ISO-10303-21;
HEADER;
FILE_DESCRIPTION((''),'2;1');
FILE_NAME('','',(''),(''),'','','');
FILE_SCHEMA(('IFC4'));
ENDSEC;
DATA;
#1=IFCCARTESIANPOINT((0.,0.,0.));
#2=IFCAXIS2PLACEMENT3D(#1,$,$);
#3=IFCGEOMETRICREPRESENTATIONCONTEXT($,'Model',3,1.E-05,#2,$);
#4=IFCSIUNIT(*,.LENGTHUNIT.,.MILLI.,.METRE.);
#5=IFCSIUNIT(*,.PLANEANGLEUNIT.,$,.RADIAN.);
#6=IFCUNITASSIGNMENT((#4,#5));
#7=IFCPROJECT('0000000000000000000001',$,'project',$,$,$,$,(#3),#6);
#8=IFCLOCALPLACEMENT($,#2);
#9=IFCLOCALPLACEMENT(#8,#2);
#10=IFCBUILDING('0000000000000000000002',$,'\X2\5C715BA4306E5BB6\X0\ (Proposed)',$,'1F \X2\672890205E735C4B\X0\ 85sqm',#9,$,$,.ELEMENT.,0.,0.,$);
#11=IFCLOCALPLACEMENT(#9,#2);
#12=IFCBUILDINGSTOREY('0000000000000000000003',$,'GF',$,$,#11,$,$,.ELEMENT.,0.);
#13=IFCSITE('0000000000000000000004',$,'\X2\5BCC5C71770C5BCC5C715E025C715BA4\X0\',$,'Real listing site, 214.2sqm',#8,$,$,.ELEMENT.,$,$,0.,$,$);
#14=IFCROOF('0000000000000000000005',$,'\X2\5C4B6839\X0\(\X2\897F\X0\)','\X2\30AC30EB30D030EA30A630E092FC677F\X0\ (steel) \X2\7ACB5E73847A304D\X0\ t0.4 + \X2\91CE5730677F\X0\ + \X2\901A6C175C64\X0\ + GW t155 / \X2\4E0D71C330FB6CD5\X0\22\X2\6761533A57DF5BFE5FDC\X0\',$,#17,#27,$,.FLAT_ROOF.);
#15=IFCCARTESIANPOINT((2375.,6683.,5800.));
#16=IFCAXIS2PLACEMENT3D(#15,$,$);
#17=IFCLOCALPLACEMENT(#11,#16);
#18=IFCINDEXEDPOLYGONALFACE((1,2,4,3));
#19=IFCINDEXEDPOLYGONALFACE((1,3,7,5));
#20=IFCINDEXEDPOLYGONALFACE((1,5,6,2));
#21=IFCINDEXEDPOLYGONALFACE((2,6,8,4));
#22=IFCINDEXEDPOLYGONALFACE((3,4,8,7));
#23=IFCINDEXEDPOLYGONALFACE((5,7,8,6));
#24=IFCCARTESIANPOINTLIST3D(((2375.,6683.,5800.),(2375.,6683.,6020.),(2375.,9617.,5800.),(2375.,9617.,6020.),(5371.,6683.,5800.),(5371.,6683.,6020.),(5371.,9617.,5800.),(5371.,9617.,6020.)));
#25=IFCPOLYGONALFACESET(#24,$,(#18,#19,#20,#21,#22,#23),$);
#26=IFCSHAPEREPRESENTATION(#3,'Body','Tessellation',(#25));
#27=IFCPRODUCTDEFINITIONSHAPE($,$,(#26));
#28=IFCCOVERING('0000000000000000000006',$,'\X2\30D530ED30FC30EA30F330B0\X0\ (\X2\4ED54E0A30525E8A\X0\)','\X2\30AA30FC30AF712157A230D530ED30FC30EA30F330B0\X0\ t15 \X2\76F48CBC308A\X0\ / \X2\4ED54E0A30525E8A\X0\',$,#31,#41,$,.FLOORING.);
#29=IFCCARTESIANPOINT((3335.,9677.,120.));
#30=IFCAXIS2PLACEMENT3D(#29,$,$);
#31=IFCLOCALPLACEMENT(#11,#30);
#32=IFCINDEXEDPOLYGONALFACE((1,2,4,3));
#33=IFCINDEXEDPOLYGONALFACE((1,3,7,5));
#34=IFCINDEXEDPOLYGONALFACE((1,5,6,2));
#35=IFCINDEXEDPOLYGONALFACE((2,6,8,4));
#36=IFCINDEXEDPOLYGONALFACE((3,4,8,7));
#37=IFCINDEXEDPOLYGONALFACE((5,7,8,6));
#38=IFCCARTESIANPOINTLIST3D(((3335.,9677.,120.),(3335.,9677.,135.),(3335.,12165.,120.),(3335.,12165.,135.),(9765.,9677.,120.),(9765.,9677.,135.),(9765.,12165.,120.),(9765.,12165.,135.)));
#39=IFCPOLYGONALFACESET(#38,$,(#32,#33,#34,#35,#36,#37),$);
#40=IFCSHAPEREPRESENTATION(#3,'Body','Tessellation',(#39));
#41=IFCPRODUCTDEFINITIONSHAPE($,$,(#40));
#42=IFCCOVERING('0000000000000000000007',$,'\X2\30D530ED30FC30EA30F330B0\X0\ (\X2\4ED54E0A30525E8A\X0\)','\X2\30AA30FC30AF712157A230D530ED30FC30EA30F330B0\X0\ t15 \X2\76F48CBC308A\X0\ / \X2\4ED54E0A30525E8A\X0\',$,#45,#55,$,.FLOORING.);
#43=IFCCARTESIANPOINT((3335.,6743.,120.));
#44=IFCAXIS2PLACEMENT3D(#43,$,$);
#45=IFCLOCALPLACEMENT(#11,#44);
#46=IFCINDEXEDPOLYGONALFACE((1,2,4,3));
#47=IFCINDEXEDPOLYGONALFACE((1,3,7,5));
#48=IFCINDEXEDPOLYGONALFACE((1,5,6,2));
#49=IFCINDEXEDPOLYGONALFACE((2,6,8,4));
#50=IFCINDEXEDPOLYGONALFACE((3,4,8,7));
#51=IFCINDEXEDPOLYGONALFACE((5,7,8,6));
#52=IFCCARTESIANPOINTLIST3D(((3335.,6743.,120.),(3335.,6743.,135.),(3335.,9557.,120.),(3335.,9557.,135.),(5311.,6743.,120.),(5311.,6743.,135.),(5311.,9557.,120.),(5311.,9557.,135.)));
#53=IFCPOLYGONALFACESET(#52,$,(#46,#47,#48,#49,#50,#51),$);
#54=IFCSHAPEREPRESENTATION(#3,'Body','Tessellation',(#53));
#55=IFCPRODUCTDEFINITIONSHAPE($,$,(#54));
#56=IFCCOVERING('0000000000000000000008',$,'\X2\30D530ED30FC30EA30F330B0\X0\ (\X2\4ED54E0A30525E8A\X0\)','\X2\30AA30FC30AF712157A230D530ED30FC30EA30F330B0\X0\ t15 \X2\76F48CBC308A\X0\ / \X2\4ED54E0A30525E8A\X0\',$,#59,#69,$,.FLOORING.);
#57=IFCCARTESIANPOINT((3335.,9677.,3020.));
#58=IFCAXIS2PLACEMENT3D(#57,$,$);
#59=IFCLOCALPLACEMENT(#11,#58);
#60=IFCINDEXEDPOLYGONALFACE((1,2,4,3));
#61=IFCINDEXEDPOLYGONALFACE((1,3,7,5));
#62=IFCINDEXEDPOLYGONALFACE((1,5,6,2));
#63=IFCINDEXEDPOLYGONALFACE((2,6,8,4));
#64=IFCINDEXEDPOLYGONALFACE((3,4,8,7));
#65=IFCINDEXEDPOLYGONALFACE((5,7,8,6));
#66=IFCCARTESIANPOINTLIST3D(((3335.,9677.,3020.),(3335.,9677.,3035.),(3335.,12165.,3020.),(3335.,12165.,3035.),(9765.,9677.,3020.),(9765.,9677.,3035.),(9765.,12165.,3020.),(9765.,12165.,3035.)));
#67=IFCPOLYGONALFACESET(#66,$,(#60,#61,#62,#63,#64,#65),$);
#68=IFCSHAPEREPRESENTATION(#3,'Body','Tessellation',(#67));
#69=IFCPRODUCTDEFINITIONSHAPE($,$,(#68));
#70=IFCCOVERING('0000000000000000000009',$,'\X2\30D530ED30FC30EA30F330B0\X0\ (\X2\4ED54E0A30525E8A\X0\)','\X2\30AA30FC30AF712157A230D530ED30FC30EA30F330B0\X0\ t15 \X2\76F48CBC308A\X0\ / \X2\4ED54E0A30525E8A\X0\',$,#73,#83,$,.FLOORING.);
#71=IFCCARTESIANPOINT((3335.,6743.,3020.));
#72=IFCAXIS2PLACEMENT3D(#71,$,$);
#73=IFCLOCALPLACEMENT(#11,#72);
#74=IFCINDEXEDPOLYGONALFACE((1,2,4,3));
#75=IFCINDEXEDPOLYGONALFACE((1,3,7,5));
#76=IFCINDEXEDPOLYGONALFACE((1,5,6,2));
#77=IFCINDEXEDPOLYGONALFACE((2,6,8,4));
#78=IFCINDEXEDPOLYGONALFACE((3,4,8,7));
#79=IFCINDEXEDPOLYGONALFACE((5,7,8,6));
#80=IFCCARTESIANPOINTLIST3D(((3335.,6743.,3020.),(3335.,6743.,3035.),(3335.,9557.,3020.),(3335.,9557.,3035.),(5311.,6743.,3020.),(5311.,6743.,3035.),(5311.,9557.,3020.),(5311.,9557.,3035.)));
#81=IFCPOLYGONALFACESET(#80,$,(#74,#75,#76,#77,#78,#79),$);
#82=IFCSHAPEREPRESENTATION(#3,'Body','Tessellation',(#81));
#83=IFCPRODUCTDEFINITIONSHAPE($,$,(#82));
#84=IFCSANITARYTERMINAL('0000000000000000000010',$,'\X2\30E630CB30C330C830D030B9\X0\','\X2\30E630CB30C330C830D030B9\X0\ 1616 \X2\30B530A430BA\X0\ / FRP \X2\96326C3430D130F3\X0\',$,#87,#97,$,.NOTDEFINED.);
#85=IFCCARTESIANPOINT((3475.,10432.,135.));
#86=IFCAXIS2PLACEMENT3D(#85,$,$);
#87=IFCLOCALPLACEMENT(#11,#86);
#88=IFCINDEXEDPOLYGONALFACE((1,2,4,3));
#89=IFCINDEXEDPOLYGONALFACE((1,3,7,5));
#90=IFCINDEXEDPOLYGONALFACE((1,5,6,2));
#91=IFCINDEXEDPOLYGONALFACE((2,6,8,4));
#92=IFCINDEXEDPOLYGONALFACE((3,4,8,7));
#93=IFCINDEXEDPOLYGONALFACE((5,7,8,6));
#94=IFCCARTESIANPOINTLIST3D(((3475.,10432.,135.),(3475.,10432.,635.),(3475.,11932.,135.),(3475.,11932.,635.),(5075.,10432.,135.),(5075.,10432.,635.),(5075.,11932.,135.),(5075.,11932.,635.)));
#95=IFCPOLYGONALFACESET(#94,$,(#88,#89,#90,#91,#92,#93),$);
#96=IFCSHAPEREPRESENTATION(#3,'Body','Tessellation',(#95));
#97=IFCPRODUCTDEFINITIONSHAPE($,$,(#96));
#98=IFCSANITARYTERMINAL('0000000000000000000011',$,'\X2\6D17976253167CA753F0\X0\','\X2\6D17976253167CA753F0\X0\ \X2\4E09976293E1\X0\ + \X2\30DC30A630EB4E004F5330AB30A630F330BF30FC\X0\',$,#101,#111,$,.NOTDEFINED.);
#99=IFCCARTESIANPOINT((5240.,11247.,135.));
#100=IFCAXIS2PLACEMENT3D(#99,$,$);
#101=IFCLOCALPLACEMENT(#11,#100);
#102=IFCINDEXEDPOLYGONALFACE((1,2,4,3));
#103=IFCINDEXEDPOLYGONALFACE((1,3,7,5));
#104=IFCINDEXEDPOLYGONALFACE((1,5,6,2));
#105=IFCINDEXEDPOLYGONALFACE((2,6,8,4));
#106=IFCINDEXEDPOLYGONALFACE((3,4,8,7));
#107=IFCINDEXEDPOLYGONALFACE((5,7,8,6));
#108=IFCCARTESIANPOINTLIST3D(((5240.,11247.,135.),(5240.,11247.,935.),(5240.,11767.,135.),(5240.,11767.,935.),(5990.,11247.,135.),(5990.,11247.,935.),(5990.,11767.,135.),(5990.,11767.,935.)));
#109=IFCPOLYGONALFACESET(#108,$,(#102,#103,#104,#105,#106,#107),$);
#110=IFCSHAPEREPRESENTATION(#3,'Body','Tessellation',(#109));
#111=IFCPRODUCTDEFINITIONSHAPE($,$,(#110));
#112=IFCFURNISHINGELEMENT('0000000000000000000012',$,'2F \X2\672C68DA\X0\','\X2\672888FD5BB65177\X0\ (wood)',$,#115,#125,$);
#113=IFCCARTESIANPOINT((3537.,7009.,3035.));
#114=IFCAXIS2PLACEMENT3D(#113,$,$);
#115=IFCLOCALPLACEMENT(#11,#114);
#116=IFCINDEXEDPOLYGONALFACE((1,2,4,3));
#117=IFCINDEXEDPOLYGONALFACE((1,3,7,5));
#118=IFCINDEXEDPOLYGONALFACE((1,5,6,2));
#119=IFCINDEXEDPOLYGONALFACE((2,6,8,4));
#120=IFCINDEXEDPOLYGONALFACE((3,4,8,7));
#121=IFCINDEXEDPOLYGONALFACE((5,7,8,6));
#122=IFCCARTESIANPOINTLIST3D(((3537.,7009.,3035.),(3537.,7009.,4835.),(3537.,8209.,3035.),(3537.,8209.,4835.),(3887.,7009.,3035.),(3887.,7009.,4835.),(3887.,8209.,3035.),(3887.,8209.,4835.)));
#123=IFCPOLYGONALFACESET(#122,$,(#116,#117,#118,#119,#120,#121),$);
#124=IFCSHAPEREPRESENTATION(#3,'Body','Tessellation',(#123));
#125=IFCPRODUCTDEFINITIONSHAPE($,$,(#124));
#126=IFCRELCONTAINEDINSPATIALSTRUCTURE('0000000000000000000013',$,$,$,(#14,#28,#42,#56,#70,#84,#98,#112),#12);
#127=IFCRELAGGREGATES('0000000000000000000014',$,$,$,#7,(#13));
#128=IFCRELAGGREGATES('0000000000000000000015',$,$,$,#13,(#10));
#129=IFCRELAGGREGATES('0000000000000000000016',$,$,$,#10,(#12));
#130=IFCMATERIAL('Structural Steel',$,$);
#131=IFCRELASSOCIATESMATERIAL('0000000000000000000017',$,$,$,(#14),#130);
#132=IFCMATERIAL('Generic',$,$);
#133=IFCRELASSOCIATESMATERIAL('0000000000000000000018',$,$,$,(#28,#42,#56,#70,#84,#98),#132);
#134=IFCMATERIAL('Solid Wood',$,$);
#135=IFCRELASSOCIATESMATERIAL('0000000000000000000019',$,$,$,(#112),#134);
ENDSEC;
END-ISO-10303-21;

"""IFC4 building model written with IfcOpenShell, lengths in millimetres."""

from ifc_helpers import new_model, si_unit, frame, frame_2d, origin, place, context, project, spatial, rectangle, extrude, material, element, save


model = new_model("IFC4")

# Units and contexts
model_context = context("Model", 3, precision=1e-05, world=origin())
ifc_project = project(units=[si_unit("LENGTHUNIT", "METRE", prefix="MILLI"), si_unit("PLANEANGLEUNIT", "RADIAN")], contexts=[model_context])

# Site, building, storey
site_placement = place(None, origin())
site = spatial("IfcSite", under=ifc_project, at=site_placement, Name="富山県富山市山室", ObjectType="Real listing site, 214.2sqm", CompositionType="ELEMENT", RefElevation=0.0)
building_placement = place(site_placement, origin())
building = spatial("IfcBuilding", under=site, at=building_placement, Name="山室の家 (Proposed)", ObjectType="1F 木造平屋 85sqm", CompositionType="ELEMENT", ElevationOfRefHeight=0.0, ElevationOfTerrain=0.0)
storey_placement = place(building_placement, origin())
storey = spatial("IfcBuildingStorey", under=building, at=storey_placement, Name="GF", CompositionType="ELEMENT", Elevation=0.0)

# Shared definitions
ifc_material_1 = material(Name="Solid Wood")

# Roof
ifc_material_2 = material(Name="Structural Steel")
roof_placement = place(storey_placement, frame((2375.0, 6683.0, 5800.0)))
element("IfcRoof", 1, at=roof_placement, inside=storey, material=ifc_material_2, Name="屋根(西)", Description="ガルバリウム鋼板 (steel) 立平葺き t0.4 + 野地板 + 通気層 + GW t155 / 不燃・法22条区域対応", PredefinedType="FLAT_ROOF", context=model_context, shape_type="SweptSolid", body=[
    extrude(rectangle(XDim=2996.0, YDim=2934.0, at=frame_2d((1498.0, 1467.0))), frame((2375.0, 6683.0, 5800.0)), (0.0, 0.0, 1.0), 220.0),
])

# Coverings
ifc_material_3 = material(Name="Generic")
covering_1_placement = place(storey_placement, frame((3335.0, 9677.0, 120.0)))
element("IfcCovering", 2, at=covering_1_placement, inside=storey, material=ifc_material_3, Name="フローリング (仕上げ床)", Description="オーク無垢フローリング t15 直貼り / 仕上げ床", PredefinedType="FLOORING", context=model_context, shape_type="SweptSolid", body=[
    extrude(rectangle(XDim=6430.0, YDim=2488.0, at=frame_2d((3215.0, 1244.0))), frame((3335.0, 9677.0, 120.0)), (0.0, 0.0, 1.0), 15.0),
])
covering_2_placement = place(storey_placement, frame((3335.0, 6743.0, 120.0)))
element("IfcCovering", 3, at=covering_2_placement, inside=storey, material=ifc_material_3, Name="フローリング (仕上げ床)", Description="オーク無垢フローリング t15 直貼り / 仕上げ床", PredefinedType="FLOORING", context=model_context, shape_type="SweptSolid", body=[
    extrude(rectangle(XDim=1976.0, YDim=2814.0, at=frame_2d((988.0, 1407.0))), frame((3335.0, 6743.0, 120.0)), (0.0, 0.0, 1.0), 15.0),
])
covering_3_placement = place(storey_placement, frame((3335.0, 9677.0, 3020.0)))
element("IfcCovering", 4, at=covering_3_placement, inside=storey, material=ifc_material_3, Name="フローリング (仕上げ床)", Description="オーク無垢フローリング t15 直貼り / 仕上げ床", PredefinedType="FLOORING", context=model_context, shape_type="SweptSolid", body=[
    extrude(rectangle(XDim=6430.0, YDim=2488.0, at=frame_2d((3215.0, 1244.0))), frame((3335.0, 9677.0, 3020.0)), (0.0, 0.0, 1.0), 15.0),
])
covering_4_placement = place(storey_placement, frame((3335.0, 6743.0, 3020.0)))
element("IfcCovering", 5, at=covering_4_placement, inside=storey, material=ifc_material_3, Name="フローリング (仕上げ床)", Description="オーク無垢フローリング t15 直貼り / 仕上げ床", PredefinedType="FLOORING", context=model_context, shape_type="SweptSolid", body=[
    extrude(rectangle(XDim=1976.0, YDim=2814.0, at=frame_2d((988.0, 1407.0))), frame((3335.0, 6743.0, 3020.0)), (0.0, 0.0, 1.0), 15.0),
])

# Sanitary terminals
sanitary_terminal_1_placement = place(storey_placement, frame((3475.0, 10432.0, 135.0)))
element("IfcSanitaryTerminal", 6, at=sanitary_terminal_1_placement, inside=storey, material=ifc_material_3, Name="ユニットバス", Description="ユニットバス 1616 サイズ / FRP 防水パン", PredefinedType="NOTDEFINED", context=model_context, shape_type="SweptSolid", body=[
    extrude(rectangle(XDim=1600.0, YDim=1500.0, at=frame_2d((800.0, 750.0))), frame((3475.0, 10432.0, 135.0)), (0.0, 0.0, 1.0), 500.0),
])
sanitary_terminal_2_placement = place(storey_placement, frame((5240.0, 11247.0, 135.0)))
element("IfcSanitaryTerminal", 7, at=sanitary_terminal_2_placement, inside=storey, material=ifc_material_3, Name="洗面化粧台", Description="洗面化粧台 三面鏡 + ボウル一体カウンター", PredefinedType="NOTDEFINED", context=model_context, shape_type="SweptSolid", body=[
    extrude(rectangle(XDim=750.0, YDim=520.0, at=frame_2d((375.0, 260.0))), frame((5240.0, 11247.0, 135.0)), (0.0, 0.0, 1.0), 800.0),
])

# Furnishing element
furnishing_placement = place(storey_placement, frame((3537.0, 7009.0, 3035.0)))
element("IfcFurnishingElement", 8, at=furnishing_placement, inside=storey, material=ifc_material_1, Name="2F 本棚", Description="木製家具 (wood)", context=model_context, shape_type="SweptSolid", body=[
    extrude(rectangle(XDim=350.0, YDim=1200.0, at=frame_2d((175.0, 600.0))), frame((3537.0, 7009.0, 3035.0)), (0.0, 0.0, 1.0), 1800.0),
])

save(model, "model.ifc")
